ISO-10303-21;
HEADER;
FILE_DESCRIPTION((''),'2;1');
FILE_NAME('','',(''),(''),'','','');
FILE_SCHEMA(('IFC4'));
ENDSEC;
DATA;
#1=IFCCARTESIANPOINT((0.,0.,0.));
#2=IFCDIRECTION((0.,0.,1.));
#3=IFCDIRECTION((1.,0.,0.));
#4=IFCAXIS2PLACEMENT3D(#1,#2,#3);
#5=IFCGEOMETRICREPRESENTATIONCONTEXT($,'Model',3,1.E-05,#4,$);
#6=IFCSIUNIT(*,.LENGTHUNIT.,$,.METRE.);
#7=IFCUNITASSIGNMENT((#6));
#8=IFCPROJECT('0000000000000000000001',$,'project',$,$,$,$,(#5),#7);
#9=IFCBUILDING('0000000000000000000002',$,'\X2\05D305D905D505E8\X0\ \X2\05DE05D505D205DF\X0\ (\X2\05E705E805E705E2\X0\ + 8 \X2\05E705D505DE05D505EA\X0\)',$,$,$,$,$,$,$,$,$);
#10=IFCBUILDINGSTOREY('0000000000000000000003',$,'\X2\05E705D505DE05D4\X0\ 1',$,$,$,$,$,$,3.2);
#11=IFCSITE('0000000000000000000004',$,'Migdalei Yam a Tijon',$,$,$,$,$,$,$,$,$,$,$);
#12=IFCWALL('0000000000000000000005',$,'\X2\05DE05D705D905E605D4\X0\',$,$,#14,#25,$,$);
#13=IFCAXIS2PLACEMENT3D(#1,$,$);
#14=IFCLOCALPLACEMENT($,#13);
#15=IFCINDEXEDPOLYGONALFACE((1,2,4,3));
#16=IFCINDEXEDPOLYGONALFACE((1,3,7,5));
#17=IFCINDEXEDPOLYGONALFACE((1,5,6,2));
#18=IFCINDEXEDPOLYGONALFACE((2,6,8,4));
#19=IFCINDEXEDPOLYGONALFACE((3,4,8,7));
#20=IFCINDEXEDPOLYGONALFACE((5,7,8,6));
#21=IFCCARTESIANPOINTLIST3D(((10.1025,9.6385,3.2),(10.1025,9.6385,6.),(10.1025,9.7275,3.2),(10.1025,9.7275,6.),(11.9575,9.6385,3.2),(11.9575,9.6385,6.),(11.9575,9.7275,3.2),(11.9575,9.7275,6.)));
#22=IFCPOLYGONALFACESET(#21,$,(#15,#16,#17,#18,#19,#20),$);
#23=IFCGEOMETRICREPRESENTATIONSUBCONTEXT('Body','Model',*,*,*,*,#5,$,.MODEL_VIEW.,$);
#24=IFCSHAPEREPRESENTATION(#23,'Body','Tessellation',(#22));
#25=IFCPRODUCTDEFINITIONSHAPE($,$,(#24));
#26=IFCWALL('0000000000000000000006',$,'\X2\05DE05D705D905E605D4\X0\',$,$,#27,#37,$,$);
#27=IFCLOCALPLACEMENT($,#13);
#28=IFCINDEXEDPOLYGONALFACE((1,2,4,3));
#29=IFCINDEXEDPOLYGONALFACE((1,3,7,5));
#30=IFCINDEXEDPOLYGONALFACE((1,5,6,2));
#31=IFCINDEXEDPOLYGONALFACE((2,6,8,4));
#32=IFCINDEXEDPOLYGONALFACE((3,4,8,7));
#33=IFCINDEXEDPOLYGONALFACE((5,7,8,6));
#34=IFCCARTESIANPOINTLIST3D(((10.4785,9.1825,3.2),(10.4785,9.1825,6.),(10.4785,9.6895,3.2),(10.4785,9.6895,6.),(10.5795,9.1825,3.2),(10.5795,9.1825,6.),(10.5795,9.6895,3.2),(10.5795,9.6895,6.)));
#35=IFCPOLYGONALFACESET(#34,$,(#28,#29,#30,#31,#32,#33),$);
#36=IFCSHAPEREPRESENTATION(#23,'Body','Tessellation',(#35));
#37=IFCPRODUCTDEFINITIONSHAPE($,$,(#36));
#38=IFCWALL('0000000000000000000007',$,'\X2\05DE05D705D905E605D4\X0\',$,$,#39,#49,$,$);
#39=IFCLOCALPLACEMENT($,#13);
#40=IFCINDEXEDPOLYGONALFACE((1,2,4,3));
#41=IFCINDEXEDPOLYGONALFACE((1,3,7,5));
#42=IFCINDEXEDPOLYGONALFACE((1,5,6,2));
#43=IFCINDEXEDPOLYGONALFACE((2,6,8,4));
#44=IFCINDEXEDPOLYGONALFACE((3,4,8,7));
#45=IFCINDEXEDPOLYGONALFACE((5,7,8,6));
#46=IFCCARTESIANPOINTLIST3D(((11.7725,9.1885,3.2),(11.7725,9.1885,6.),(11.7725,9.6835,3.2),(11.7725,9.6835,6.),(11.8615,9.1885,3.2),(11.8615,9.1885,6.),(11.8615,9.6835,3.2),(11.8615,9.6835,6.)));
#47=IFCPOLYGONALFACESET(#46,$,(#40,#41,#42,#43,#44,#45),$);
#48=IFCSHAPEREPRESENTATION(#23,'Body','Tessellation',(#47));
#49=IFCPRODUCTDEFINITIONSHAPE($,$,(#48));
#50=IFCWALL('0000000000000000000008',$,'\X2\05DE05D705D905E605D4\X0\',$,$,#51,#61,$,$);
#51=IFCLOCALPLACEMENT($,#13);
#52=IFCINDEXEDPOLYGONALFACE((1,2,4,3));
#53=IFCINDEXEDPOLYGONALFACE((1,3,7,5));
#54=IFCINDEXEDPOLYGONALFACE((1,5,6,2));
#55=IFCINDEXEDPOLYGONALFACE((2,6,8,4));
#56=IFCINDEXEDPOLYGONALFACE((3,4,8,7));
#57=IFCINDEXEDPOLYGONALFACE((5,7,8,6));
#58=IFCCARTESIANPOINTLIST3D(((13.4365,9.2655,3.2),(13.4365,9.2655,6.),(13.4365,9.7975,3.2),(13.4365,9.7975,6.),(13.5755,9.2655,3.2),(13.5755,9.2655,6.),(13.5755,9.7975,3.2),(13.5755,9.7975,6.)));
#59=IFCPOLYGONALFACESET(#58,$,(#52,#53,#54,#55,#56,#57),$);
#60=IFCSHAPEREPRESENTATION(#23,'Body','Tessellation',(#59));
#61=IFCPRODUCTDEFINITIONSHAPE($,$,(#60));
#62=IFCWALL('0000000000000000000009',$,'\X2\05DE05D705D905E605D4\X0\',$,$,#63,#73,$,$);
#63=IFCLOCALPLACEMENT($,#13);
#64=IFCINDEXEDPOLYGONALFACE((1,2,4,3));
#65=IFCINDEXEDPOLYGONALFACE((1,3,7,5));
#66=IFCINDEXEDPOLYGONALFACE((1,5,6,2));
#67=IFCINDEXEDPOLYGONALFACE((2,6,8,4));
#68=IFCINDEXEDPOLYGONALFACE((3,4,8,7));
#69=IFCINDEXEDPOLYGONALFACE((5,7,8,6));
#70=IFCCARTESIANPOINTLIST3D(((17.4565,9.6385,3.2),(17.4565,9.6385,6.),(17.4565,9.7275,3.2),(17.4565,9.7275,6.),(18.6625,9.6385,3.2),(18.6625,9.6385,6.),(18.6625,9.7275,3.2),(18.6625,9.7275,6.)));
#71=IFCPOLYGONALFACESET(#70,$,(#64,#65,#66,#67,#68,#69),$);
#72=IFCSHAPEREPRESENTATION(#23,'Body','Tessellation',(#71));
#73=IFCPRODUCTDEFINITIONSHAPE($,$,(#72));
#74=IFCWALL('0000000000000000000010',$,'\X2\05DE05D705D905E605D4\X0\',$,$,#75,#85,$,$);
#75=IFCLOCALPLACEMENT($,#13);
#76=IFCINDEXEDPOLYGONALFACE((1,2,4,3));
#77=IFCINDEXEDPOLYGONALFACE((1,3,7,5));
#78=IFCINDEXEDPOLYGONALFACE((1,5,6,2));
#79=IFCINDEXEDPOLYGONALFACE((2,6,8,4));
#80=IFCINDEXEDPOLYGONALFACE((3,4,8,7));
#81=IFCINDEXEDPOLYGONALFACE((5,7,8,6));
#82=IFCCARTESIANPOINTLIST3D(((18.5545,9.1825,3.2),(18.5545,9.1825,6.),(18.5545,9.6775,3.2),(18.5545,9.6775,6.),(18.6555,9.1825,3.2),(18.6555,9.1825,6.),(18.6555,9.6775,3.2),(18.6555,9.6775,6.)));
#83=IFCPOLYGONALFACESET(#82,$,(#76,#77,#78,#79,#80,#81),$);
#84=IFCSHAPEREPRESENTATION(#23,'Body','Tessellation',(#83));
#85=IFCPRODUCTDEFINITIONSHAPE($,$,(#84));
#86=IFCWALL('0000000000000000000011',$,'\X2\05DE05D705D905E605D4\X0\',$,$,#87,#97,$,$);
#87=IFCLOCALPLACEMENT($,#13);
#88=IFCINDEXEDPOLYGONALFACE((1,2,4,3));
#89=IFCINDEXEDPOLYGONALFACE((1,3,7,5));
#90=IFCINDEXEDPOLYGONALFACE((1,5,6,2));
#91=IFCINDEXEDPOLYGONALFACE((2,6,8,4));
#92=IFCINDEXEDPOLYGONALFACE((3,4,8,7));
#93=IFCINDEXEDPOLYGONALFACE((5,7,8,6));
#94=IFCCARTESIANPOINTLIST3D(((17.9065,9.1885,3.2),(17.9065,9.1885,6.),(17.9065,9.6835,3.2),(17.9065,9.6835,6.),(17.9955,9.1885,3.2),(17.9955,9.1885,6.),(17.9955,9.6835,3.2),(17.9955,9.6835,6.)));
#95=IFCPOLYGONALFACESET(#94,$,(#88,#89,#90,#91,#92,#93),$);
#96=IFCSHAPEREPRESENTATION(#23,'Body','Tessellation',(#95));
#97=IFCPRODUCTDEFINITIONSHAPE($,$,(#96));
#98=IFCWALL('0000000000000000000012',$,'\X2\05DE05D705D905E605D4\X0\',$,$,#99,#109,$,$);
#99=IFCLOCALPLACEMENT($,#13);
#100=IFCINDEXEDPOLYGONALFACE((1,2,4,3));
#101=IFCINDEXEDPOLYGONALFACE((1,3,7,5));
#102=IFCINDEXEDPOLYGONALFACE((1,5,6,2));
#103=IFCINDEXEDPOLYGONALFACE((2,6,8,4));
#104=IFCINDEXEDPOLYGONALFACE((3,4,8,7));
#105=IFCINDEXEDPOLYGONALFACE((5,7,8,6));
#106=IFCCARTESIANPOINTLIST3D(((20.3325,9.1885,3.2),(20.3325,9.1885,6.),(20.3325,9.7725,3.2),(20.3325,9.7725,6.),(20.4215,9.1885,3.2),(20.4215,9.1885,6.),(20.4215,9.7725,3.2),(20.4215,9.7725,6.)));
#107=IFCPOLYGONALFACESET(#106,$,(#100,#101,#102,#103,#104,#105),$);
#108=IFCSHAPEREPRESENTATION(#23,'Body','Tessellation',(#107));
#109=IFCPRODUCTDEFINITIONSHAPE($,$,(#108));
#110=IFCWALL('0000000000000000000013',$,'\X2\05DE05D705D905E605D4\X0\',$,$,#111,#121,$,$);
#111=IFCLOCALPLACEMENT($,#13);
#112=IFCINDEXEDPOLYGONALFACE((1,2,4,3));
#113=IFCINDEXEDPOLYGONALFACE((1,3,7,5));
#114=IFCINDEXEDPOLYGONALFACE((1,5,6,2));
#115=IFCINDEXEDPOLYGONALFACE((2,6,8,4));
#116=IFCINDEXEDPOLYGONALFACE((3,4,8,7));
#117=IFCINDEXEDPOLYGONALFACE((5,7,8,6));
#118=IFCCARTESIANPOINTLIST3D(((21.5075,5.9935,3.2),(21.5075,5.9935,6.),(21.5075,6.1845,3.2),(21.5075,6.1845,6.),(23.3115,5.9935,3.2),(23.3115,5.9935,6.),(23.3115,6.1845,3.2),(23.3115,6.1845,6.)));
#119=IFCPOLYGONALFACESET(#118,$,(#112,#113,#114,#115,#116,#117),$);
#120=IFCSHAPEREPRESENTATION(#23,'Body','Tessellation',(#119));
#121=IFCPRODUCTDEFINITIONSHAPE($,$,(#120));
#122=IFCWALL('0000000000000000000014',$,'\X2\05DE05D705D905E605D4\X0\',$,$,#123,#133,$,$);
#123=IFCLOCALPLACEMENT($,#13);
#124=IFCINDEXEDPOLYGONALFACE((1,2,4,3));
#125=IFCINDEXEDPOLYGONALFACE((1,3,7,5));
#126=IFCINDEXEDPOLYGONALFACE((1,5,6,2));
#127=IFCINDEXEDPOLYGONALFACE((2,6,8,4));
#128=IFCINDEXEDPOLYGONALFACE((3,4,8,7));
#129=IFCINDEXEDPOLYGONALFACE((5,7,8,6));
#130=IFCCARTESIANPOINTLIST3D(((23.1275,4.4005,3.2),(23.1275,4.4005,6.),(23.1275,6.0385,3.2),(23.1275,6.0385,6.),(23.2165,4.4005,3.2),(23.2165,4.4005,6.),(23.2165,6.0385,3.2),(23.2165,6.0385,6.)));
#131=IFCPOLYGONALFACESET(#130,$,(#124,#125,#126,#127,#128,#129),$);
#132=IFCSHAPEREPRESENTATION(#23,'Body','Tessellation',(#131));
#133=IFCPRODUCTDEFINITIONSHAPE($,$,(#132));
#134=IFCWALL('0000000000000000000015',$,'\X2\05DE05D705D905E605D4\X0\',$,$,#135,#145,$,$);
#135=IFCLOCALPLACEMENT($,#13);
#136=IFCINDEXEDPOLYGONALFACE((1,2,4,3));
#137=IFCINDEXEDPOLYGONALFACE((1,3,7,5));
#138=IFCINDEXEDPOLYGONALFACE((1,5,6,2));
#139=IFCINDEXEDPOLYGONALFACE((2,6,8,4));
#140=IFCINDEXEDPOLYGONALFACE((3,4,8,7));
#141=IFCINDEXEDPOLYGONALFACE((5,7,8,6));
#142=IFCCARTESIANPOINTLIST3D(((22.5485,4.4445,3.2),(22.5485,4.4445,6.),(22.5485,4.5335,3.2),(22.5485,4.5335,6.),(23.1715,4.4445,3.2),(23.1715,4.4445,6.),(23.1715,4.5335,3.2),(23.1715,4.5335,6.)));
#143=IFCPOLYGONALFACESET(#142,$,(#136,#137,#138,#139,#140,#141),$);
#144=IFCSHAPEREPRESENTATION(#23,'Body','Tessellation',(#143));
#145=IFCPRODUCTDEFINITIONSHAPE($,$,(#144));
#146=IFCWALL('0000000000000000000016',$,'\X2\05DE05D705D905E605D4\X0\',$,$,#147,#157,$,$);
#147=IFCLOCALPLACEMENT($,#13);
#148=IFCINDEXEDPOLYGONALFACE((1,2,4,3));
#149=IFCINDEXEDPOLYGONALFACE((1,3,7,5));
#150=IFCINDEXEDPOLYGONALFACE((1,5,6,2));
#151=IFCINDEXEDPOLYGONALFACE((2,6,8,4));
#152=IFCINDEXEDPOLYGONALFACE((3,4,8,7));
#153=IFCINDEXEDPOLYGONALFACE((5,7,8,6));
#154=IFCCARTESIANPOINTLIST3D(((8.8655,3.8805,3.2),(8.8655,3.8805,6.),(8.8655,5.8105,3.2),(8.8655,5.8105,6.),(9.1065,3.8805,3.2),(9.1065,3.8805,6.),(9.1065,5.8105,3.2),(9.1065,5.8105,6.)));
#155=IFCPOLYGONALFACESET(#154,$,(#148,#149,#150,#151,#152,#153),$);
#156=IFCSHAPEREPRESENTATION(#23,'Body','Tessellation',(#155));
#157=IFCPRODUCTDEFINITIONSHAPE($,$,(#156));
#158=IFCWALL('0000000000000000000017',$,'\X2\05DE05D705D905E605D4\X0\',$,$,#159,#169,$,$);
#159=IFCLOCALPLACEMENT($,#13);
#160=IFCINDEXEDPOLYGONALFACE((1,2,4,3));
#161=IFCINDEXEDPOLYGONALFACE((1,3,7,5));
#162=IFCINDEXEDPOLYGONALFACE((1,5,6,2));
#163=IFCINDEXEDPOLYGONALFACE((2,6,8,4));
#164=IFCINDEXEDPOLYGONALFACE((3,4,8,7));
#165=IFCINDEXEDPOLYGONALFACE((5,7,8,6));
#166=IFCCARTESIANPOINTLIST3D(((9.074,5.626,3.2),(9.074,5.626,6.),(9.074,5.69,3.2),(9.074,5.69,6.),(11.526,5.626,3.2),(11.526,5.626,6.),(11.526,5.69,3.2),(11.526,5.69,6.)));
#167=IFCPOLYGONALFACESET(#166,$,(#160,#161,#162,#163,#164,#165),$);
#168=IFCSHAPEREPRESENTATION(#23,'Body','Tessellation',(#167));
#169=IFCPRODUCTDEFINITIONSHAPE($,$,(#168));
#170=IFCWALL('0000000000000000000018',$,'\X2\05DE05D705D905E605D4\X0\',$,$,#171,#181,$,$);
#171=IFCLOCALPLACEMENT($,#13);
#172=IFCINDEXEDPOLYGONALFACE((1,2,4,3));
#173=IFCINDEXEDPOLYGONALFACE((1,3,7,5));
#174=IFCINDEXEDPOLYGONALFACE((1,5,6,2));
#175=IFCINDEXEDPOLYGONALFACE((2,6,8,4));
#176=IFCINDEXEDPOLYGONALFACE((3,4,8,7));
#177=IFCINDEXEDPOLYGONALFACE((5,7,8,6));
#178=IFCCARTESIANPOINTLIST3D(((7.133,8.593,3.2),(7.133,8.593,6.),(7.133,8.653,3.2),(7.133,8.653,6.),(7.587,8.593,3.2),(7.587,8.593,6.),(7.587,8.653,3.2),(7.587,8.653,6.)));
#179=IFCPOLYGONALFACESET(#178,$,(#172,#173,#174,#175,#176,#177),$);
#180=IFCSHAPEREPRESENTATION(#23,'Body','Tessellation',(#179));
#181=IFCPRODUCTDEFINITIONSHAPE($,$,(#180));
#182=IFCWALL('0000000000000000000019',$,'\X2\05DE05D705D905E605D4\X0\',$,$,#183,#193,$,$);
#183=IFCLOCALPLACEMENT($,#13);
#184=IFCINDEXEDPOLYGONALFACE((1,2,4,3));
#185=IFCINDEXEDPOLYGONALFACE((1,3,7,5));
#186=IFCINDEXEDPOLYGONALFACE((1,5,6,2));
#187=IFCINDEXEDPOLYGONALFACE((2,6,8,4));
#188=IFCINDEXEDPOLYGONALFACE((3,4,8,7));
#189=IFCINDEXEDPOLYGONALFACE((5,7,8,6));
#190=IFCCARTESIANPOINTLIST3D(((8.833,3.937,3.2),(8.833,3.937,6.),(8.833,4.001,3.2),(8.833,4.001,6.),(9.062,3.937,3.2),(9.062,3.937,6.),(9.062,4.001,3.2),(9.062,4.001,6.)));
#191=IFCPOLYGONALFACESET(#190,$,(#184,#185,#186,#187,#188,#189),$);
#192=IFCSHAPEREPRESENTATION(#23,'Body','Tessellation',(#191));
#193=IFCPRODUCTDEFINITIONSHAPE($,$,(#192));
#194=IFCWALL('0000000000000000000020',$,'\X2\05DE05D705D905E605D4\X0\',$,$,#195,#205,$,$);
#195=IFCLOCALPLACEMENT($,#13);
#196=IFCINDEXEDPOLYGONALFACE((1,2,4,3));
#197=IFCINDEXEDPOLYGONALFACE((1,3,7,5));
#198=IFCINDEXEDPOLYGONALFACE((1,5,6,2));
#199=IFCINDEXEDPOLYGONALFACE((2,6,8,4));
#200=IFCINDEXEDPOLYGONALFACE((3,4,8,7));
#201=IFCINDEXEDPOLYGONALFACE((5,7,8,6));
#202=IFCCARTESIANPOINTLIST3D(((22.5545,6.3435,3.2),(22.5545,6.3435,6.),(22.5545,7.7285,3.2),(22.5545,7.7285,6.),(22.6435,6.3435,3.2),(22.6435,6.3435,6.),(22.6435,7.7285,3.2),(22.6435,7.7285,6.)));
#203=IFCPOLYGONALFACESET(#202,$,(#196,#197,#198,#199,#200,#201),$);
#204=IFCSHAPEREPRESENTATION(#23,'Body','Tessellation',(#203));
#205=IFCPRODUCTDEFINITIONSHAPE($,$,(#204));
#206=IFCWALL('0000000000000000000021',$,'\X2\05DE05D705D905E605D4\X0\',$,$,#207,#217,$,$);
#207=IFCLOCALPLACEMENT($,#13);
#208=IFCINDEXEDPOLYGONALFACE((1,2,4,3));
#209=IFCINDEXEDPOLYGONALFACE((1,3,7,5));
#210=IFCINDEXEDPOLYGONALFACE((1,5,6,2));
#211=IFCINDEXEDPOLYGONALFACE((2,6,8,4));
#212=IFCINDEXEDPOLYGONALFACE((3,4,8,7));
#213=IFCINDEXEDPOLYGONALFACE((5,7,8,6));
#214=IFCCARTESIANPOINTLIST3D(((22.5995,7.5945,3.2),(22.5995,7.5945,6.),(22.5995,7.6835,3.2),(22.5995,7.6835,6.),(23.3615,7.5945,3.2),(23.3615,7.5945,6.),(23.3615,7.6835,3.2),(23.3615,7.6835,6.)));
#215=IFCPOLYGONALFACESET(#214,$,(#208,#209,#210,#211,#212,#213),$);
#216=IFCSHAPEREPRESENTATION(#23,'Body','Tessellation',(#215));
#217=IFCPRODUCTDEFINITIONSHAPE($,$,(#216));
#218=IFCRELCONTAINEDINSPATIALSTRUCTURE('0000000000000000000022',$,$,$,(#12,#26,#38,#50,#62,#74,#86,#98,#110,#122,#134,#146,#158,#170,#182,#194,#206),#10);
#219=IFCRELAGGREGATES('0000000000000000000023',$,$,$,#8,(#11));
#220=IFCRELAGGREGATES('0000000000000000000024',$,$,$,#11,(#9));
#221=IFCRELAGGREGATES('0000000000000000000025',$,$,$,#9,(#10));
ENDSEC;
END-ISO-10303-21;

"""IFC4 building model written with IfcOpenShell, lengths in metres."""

from ifc_helpers import new_model, si_unit, frame, origin_with_axes, context, subcontext, project, spatial, line, indexed_curve, outline, extrude, element, save


model = new_model("IFC4")

# Units and contexts
model_context = context("Model", 3, precision=1e-05, world=origin_with_axes())
body_context = subcontext(model_context, "Body", "Model", "MODEL_VIEW")
ifc_project = project(units=[si_unit("LENGTHUNIT", "METRE")], contexts=[model_context])

# Site, building, storey
site = spatial("IfcSite", under=ifc_project, Name="Migdalei Yam a Tijon")
building = spatial("IfcBuilding", under=site, Name="דיור מוגן (קרקע + 8 קומות)")
storey = spatial("IfcBuildingStorey", under=building, Name="קומה 1", Elevation=3.2)

# Walls
element("IfcWall", 1, inside=storey, Name="מחיצה", context=body_context, shape_type="SweptSolid", body=[
    extrude(outline(indexed_curve([(0.0, 0.0), (1.855, 0.0), (1.855, 0.089), (0.0, 0.089)], segments=[line(1, 2, 3, 4, 1)])), frame((10.1025, 9.6385, 3.2), z_axis=(0.0, 0.0, 1.0), x_axis=(1.0, 0.0, 0.0)), (0.0, 0.0, 1.0), 2.8),
])
element("IfcWall", 2, inside=storey, Name="מחיצה", context=body_context, shape_type="SweptSolid", body=[
    extrude(outline(indexed_curve([(0.0, 0.0), (0.101, 0.0), (0.101, 0.507), (0.0, 0.507)], segments=[line(1, 2, 3, 4, 1)])), frame((10.4785, 9.1825, 3.2), z_axis=(0.0, 0.0, 1.0), x_axis=(1.0, 0.0, 0.0)), (0.0, 0.0, 1.0), 2.8),
])
element("IfcWall", 3, inside=storey, Name="מחיצה", context=body_context, shape_type="SweptSolid", body=[
    extrude(outline(indexed_curve([(0.0, 0.0), (0.089, 0.0), (0.089, 0.495), (0.0, 0.495)], segments=[line(1, 2, 3, 4, 1)])), frame((11.7725, 9.1885, 3.2), z_axis=(0.0, 0.0, 1.0), x_axis=(1.0, 0.0, 0.0)), (0.0, 0.0, 1.0), 2.8),
])
element("IfcWall", 4, inside=storey, Name="מחיצה", context=body_context, shape_type="SweptSolid", body=[
    extrude(outline(indexed_curve([(0.0, 0.0), (0.139, 0.0), (0.139, 0.532), (0.0, 0.532)], segments=[line(1, 2, 3, 4, 1)])), frame((13.4365, 9.2655, 3.2), z_axis=(0.0, 0.0, 1.0), x_axis=(1.0, 0.0, 0.0)), (0.0, 0.0, 1.0), 2.8),
])
element("IfcWall", 5, inside=storey, Name="מחיצה", context=body_context, shape_type="SweptSolid", body=[
    extrude(outline(indexed_curve([(0.0, 0.0), (1.206, 0.0), (1.206, 0.089), (0.0, 0.089)], segments=[line(1, 2, 3, 4, 1)])), frame((17.4565, 9.6385, 3.2), z_axis=(0.0, 0.0, 1.0), x_axis=(1.0, 0.0, 0.0)), (0.0, 0.0, 1.0), 2.8),
])
element("IfcWall", 6, inside=storey, Name="מחיצה", context=body_context, shape_type="SweptSolid", body=[
    extrude(outline(indexed_curve([(0.0, 0.0), (0.101, 0.0), (0.101, 0.495), (0.0, 0.495)], segments=[line(1, 2, 3, 4, 1)])), frame((18.5545, 9.1825, 3.2), z_axis=(0.0, 0.0, 1.0), x_axis=(1.0, 0.0, 0.0)), (0.0, 0.0, 1.0), 2.8),
])
element("IfcWall", 7, inside=storey, Name="מחיצה", context=body_context, shape_type="SweptSolid", body=[
    extrude(outline(indexed_curve([(0.0, 0.0), (0.089, 0.0), (0.089, 0.495), (0.0, 0.495)], segments=[line(1, 2, 3, 4, 1)])), frame((17.9065, 9.1885, 3.2), z_axis=(0.0, 0.0, 1.0), x_axis=(1.0, 0.0, 0.0)), (0.0, 0.0, 1.0), 2.8),
])
element("IfcWall", 8, inside=storey, Name="מחיצה", context=body_context, shape_type="SweptSolid", body=[
    extrude(outline(indexed_curve([(0.0, 0.0), (0.089, 0.0), (0.089, 0.584), (0.0, 0.584)], segments=[line(1, 2, 3, 4, 1)])), frame((20.3325, 9.1885, 3.2), z_axis=(0.0, 0.0, 1.0), x_axis=(1.0, 0.0, 0.0)), (0.0, 0.0, 1.0), 2.8),
])
element("IfcWall", 9, inside=storey, Name="מחיצה", context=body_context, shape_type="SweptSolid", body=[
    extrude(outline(indexed_curve([(0.0, 0.0), (1.804, 0.0), (1.804, 0.191), (0.0, 0.191)], segments=[line(1, 2, 3, 4, 1)])), frame((21.5075, 5.9935, 3.2), z_axis=(0.0, 0.0, 1.0), x_axis=(1.0, 0.0, 0.0)), (0.0, 0.0, 1.0), 2.8),
])
element("IfcWall", 10, inside=storey, Name="מחיצה", context=body_context, shape_type="SweptSolid", body=[
    extrude(outline(indexed_curve([(0.0, 0.0), (0.089, 0.0), (0.089, 1.638), (0.0, 1.638)], segments=[line(1, 2, 3, 4, 1)])), frame((23.1275, 4.4005, 3.2), z_axis=(0.0, 0.0, 1.0), x_axis=(1.0, 0.0, 0.0)), (0.0, 0.0, 1.0), 2.8),
])
element("IfcWall", 11, inside=storey, Name="מחיצה", context=body_context, shape_type="SweptSolid", body=[
    extrude(outline(indexed_curve([(0.0, 0.0), (0.623, 0.0), (0.623, 0.089), (0.0, 0.089)], segments=[line(1, 2, 3, 4, 1)])), frame((22.5485, 4.4445, 3.2), z_axis=(0.0, 0.0, 1.0), x_axis=(1.0, 0.0, 0.0)), (0.0, 0.0, 1.0), 2.8),
])
element("IfcWall", 12, inside=storey, Name="מחיצה", context=body_context, shape_type="SweptSolid", body=[
    extrude(outline(indexed_curve([(0.0, 0.0), (0.241, 0.0), (0.241, 1.93), (0.0, 1.93)], segments=[line(1, 2, 3, 4, 1)])), frame((8.8655, 3.8805, 3.2), z_axis=(0.0, 0.0, 1.0), x_axis=(1.0, 0.0, 0.0)), (0.0, 0.0, 1.0), 2.8),
])
element("IfcWall", 13, inside=storey, Name="מחיצה", context=body_context, shape_type="SweptSolid", body=[
    extrude(outline(indexed_curve([(0.0, 0.0), (2.452, 0.0), (2.452, 0.064), (0.0, 0.064)], segments=[line(1, 2, 3, 4, 1)])), frame((9.074, 5.626, 3.2), z_axis=(0.0, 0.0, 1.0), x_axis=(1.0, 0.0, 0.0)), (0.0, 0.0, 1.0), 2.8),
])
element("IfcWall", 14, inside=storey, Name="מחיצה", context=body_context, shape_type="SweptSolid", body=[
    extrude(outline(indexed_curve([(0.0, 0.0), (0.454, 0.0), (0.454, 0.06), (0.0, 0.06)], segments=[line(1, 2, 3, 4, 1)])), frame((7.133, 8.593, 3.2), z_axis=(0.0, 0.0, 1.0), x_axis=(1.0, 0.0, 0.0)), (0.0, 0.0, 1.0), 2.8),
])
element("IfcWall", 15, inside=storey, Name="מחיצה", context=body_context, shape_type="SweptSolid", body=[
    extrude(outline(indexed_curve([(0.0, 0.0), (0.229, 0.0), (0.229, 0.064), (0.0, 0.064)], segments=[line(1, 2, 3, 4, 1)])), frame((8.833, 3.937, 3.2), z_axis=(0.0, 0.0, 1.0), x_axis=(1.0, 0.0, 0.0)), (0.0, 0.0, 1.0), 2.8),
])
element("IfcWall", 16, inside=storey, Name="מחיצה", context=body_context, shape_type="SweptSolid", body=[
    extrude(outline(indexed_curve([(0.0, 0.0), (0.089, 0.0), (0.089, 1.385), (0.0, 1.385)], segments=[line(1, 2, 3, 4, 1)])), frame((22.5545, 6.3435, 3.2), z_axis=(0.0, 0.0, 1.0), x_axis=(1.0, 0.0, 0.0)), (0.0, 0.0, 1.0), 2.8),
])
element("IfcWall", 17, inside=storey, Name="מחיצה", context=body_context, shape_type="SweptSolid", body=[
    extrude(outline(indexed_curve([(0.0, 0.0), (0.762, 0.0), (0.762, 0.089), (0.0, 0.089)], segments=[line(1, 2, 3, 4, 1)])), frame((22.5995, 7.5945, 3.2), z_axis=(0.0, 0.0, 1.0), x_axis=(1.0, 0.0, 0.0)), (0.0, 0.0, 1.0), 2.8),
])

save(model, "model.ifc")
